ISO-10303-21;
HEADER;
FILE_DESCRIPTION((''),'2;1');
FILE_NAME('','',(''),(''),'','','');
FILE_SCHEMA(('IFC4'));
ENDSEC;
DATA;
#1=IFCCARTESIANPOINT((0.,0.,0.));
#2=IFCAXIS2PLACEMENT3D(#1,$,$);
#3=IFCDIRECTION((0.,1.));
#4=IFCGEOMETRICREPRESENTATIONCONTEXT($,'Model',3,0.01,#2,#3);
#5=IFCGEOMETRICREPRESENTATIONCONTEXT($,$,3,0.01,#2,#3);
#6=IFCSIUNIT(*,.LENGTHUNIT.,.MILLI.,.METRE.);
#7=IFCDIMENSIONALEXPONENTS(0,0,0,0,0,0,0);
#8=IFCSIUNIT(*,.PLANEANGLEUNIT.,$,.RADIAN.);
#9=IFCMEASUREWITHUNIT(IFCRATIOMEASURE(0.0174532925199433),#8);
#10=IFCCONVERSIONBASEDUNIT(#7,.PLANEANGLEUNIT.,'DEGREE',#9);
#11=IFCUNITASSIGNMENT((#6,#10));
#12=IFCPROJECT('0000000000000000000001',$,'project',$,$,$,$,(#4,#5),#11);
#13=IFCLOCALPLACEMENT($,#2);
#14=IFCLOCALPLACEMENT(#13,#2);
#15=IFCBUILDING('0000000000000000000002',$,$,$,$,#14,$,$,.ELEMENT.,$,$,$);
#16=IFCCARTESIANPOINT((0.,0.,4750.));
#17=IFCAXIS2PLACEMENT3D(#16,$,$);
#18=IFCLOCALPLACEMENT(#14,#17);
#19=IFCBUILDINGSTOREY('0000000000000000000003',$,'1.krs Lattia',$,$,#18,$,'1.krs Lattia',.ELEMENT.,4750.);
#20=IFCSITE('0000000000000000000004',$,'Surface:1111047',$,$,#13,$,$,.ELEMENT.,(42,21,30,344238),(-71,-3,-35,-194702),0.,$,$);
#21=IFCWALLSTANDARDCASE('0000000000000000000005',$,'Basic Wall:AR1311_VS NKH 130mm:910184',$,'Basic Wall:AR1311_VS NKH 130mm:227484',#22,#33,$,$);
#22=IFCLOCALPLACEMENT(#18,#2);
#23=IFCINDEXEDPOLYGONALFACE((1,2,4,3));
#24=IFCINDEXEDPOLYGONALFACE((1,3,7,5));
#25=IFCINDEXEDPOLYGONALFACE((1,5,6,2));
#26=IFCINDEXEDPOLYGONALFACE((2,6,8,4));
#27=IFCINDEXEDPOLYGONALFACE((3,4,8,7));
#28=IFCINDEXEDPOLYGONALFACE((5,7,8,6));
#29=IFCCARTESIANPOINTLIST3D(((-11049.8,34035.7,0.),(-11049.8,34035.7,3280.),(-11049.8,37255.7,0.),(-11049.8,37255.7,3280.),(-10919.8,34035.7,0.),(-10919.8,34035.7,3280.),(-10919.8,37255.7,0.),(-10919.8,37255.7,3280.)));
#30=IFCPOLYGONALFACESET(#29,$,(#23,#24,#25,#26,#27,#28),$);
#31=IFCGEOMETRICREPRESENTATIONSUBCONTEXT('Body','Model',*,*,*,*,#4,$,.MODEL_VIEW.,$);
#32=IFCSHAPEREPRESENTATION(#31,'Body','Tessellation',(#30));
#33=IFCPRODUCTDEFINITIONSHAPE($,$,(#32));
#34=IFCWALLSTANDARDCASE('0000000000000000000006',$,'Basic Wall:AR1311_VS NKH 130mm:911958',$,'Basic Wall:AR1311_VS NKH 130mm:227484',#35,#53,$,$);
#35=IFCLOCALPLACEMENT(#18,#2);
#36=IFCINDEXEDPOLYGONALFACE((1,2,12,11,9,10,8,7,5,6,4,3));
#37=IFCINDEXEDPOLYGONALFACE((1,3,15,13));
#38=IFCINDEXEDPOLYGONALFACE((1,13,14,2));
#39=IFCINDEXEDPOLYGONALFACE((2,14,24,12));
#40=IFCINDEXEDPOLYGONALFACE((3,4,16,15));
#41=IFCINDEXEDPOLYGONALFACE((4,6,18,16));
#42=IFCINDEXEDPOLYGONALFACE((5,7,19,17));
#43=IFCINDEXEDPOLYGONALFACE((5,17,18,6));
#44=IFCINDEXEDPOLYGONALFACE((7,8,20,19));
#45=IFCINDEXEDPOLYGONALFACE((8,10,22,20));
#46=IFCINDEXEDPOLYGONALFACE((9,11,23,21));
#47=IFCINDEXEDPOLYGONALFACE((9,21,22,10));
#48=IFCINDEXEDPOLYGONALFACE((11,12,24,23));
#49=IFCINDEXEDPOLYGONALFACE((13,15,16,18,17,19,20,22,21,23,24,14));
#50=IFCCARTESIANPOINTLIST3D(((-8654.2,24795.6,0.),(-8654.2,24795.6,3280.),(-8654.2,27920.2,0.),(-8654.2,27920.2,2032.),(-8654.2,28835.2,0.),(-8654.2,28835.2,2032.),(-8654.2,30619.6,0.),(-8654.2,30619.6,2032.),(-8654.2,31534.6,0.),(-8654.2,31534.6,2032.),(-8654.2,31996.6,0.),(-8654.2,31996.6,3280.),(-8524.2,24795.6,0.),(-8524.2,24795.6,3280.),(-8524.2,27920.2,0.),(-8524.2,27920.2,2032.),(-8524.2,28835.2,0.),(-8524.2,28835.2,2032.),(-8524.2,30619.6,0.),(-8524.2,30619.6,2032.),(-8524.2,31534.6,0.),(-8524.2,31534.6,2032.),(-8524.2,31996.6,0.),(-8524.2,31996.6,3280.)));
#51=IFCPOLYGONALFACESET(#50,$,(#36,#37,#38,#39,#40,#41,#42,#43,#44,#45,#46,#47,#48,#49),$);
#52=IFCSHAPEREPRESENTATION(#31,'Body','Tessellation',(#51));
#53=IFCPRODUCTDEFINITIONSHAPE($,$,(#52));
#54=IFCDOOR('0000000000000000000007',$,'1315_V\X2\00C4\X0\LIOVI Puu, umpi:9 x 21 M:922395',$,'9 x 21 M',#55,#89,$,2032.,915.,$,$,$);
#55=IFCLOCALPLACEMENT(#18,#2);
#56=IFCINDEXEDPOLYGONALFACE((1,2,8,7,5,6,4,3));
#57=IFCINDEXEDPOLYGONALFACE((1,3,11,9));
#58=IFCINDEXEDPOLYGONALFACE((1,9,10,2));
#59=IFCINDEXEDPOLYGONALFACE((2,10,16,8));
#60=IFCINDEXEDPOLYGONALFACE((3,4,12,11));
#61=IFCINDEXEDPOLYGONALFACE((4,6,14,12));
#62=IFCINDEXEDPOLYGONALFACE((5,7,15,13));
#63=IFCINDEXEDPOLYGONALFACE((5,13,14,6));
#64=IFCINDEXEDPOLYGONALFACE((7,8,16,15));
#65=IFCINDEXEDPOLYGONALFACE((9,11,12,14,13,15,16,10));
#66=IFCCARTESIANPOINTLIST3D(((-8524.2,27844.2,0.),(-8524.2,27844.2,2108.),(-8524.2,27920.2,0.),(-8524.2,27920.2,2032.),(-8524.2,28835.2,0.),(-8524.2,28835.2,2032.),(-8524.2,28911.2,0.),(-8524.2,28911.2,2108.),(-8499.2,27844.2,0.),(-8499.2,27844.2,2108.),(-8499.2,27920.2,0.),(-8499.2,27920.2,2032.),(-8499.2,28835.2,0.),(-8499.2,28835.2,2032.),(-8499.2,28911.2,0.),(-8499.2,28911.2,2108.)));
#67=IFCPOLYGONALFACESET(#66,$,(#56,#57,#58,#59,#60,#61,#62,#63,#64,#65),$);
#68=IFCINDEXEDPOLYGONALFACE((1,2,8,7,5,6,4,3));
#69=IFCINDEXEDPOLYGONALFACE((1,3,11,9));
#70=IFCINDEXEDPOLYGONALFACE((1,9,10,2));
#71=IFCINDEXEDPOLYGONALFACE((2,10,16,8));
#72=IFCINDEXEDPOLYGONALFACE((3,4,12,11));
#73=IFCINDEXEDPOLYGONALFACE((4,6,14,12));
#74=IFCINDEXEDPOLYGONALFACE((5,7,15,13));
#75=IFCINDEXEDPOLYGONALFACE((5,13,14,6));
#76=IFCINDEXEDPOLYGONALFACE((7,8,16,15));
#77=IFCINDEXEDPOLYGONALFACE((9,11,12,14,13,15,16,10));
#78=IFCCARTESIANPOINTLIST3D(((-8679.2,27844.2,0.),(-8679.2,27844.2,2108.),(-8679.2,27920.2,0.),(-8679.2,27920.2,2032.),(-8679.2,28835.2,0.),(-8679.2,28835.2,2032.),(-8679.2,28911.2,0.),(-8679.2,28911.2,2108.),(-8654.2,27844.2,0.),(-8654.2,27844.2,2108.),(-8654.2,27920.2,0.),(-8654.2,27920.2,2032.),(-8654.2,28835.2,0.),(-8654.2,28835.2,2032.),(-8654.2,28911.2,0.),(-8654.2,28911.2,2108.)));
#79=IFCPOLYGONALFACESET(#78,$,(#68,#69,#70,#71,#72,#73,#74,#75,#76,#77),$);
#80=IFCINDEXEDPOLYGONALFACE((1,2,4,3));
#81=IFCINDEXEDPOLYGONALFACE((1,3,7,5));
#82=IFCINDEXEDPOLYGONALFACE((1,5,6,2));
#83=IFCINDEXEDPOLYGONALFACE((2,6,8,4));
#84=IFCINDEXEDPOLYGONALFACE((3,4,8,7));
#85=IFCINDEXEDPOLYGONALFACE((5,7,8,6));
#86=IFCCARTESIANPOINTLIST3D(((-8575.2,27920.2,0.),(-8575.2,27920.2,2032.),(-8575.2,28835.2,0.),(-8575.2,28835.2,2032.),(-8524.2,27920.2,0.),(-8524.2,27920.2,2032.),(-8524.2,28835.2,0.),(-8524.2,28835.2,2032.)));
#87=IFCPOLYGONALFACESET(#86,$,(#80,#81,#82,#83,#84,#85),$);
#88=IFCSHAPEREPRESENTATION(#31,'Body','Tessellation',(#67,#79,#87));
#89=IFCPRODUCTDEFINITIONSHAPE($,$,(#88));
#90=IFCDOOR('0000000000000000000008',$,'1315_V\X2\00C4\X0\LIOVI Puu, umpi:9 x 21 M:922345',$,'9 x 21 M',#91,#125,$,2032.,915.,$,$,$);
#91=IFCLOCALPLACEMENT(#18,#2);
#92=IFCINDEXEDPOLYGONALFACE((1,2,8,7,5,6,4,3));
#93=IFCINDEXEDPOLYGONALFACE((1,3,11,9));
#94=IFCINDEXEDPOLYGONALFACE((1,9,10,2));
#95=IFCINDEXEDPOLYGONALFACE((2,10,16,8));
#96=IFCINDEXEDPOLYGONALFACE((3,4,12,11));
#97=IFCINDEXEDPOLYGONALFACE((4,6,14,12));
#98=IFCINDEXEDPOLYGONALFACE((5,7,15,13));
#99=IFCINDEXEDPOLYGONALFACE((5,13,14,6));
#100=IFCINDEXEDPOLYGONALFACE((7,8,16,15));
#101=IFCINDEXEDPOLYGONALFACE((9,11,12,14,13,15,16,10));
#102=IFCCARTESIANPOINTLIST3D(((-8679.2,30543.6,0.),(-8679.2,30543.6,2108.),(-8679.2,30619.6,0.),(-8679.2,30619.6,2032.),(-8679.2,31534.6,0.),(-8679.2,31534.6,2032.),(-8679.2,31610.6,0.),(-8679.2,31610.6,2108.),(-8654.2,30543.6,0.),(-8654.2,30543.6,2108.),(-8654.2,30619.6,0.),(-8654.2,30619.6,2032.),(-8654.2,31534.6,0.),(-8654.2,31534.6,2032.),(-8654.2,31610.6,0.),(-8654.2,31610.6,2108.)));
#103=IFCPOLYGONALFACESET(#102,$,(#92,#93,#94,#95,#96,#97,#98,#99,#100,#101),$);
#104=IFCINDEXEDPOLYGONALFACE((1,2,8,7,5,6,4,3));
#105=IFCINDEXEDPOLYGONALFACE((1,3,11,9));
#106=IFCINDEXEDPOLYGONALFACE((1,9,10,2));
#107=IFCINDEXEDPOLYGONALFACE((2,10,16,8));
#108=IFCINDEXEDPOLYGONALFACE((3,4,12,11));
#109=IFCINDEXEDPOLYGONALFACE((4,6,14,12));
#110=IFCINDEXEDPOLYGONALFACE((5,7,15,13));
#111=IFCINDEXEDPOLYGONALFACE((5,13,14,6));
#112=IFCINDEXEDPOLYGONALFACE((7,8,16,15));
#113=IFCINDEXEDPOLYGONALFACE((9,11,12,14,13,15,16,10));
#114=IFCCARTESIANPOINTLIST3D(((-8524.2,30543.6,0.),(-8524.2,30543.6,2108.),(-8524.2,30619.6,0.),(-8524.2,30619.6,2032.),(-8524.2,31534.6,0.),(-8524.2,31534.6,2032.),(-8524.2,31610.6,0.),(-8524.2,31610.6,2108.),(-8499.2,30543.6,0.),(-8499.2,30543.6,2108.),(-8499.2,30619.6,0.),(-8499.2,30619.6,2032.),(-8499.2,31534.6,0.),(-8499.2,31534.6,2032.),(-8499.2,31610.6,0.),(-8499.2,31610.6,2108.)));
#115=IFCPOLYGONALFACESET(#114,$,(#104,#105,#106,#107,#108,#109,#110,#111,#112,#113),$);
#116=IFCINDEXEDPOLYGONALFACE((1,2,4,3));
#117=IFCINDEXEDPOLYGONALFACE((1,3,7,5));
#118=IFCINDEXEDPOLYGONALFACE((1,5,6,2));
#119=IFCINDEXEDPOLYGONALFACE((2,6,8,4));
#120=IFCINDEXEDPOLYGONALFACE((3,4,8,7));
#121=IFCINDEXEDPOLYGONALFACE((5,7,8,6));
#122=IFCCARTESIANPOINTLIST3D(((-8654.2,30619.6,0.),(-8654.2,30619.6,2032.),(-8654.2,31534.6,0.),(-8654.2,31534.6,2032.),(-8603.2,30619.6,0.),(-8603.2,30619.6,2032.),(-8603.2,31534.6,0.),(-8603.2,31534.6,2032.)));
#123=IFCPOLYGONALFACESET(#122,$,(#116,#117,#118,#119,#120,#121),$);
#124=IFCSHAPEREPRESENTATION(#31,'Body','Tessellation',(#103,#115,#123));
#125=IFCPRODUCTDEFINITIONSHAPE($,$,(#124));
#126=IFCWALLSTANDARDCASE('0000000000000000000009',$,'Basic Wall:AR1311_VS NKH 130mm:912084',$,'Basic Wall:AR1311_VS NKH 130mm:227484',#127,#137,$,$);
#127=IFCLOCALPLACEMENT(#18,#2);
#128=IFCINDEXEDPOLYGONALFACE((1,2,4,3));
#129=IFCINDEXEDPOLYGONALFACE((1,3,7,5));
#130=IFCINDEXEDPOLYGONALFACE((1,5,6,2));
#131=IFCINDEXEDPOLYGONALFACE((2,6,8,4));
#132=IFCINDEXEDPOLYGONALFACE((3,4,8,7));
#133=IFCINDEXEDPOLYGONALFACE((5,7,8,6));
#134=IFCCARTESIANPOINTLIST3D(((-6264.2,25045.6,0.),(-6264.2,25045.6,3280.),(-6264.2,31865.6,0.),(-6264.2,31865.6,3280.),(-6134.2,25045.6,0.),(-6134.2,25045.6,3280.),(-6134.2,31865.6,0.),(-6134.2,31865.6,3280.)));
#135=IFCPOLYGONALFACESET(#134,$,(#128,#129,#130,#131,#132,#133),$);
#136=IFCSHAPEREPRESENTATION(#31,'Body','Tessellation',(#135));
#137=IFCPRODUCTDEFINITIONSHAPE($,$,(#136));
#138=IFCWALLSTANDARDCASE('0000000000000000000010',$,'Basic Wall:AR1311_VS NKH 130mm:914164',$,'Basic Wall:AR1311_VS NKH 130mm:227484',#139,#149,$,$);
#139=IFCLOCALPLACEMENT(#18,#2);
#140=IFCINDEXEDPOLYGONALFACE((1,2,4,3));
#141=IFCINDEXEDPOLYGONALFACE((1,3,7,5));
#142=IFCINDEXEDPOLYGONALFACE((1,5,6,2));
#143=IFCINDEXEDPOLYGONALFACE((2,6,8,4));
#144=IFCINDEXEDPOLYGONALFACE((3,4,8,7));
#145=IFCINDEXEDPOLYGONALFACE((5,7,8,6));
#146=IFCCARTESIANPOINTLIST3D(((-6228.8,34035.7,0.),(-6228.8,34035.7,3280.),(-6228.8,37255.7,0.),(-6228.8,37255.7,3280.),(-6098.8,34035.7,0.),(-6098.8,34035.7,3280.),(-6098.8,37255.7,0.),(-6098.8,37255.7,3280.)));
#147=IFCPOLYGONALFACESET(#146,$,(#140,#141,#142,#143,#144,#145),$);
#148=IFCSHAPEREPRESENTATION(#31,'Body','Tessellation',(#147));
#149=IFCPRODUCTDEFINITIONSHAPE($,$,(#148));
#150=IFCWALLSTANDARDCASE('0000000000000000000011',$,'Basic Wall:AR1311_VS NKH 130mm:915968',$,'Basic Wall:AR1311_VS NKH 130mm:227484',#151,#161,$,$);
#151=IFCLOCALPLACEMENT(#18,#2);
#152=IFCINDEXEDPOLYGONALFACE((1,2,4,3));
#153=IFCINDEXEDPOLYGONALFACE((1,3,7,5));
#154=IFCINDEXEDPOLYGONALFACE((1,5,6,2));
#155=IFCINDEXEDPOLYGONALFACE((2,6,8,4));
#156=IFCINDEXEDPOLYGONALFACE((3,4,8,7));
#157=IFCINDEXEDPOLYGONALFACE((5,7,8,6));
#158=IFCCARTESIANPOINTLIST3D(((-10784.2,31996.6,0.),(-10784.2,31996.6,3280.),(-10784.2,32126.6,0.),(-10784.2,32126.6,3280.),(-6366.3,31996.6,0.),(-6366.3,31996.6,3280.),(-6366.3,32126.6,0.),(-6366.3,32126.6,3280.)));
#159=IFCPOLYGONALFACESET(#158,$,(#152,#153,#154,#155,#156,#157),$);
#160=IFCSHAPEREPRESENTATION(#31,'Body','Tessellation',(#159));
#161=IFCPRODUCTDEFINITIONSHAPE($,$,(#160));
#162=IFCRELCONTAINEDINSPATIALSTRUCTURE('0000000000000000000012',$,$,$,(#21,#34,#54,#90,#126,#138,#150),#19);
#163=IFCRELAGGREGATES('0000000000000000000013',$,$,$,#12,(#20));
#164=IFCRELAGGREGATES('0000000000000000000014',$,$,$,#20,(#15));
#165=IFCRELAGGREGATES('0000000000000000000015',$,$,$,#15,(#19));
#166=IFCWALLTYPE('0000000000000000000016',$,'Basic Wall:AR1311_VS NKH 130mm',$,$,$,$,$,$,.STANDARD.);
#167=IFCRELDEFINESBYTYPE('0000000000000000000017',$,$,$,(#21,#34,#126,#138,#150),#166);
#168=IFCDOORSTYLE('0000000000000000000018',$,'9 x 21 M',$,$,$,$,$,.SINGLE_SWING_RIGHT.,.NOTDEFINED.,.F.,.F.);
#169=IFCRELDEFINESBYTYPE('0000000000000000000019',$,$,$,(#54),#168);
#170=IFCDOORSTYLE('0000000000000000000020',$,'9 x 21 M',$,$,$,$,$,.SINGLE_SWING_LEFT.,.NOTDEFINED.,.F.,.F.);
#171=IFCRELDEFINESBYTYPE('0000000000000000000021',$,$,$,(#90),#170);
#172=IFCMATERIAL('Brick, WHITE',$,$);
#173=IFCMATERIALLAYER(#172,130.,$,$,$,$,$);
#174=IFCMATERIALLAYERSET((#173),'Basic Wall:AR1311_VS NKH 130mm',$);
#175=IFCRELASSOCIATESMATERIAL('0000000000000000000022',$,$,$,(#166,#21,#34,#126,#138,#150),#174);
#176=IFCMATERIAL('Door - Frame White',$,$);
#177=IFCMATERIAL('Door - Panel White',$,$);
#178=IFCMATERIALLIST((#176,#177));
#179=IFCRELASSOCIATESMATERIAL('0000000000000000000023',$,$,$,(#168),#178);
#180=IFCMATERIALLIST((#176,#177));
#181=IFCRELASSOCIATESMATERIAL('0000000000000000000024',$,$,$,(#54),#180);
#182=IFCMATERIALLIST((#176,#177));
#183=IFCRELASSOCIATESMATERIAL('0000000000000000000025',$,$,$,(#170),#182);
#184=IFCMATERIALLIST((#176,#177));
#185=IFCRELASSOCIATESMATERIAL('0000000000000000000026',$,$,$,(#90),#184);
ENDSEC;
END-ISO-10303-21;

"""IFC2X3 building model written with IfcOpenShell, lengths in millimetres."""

from ifc_helpers import new_model, entity, si_unit, converted_unit, direction, frame, frame_2d, origin, place, context, subcontext, project, spatial, polyline, rectangle, outline, extrude, clip, bounded_halfspace, source, transform, mapped, material, material_list, layer, layer_set, layer_usage, type_object, type_shapes, element, fill, save


model = new_model("IFC2X3")

# Units and contexts
model_context = context("Model", 3, precision=0.01, world=origin(), true_north=direction((0.0, 1.0)))
context_of_model = context(None, 3, precision=0.01, world=origin(), true_north=direction((0.0, 1.0)))
body_context = subcontext(model_context, "Body", "Model", "MODEL_VIEW")
ifc_project = project(units=[si_unit("LENGTHUNIT", "METRE", prefix="MILLI"), converted_unit("PLANEANGLEUNIT", "DEGREE", entity("IfcRatioMeasure", 0.0174532925199433), si_unit("PLANEANGLEUNIT", "RADIAN"), dimensions=[0, 0, 0, 0, 0, 0, 0])], contexts=[model_context, context_of_model])

# Site, building, storey
site_placement = place(None, origin())
site = spatial("IfcSite", under=ifc_project, at=site_placement, Name="Surface:1111047", CompositionType="ELEMENT", RefLatitude=(42, 21, 30, 344238), RefLongitude=(-71, -3, -35, -194702), RefElevation=0.0)
building_placement = place(site_placement, origin())
building = spatial("IfcBuilding", under=site, at=building_placement, CompositionType="ELEMENT")
storey_placement = place(building_placement, frame((0.0, 0.0, 4750.0)))
storey = spatial("IfcBuildingStorey", under=building, at=storey_placement, Name="1.krs Lattia", LongName="1.krs Lattia", CompositionType="ELEMENT", Elevation=4750.0)

# Wall
ifc_material_1 = material(Name="Brick, WHITE")
ifc_layer = layer(ifc_material_1, 130.0)
ifc_layer_set = layer_set([ifc_layer], Name="Basic Wall:AR1311_VS NKH 130mm")
ifc_layer_usage_1 = layer_usage(ifc_layer_set, "AXIS2", "NEGATIVE", 65.0)
wall_type = type_object("IfcWallType", Name="Basic Wall:AR1311_VS NKH 130mm", PredefinedType="STANDARD", material=ifc_layer_set)
wall_1_placement = place(storey_placement, frame((-10984.8, 37255.7, 0.0), z_axis=(0.0, 0.0, 1.0), x_axis=(0.0, -1.0, 0.0)))
element("IfcWallStandardCase", 1, at=wall_1_placement, inside=storey, type_object=wall_type, material=ifc_layer_usage_1, Name="Basic Wall:AR1311_VS NKH 130mm:910184", ObjectType="Basic Wall:AR1311_VS NKH 130mm:227484", context=body_context, shape_type="Clipping", body=[
    clip(extrude(rectangle(XDim=3220.0, YDim=130.0, at=frame_2d((1610.0, 0.0), x_axis=(-1.0, 0.0))), origin(), (0.0, 0.0, 1.0), 3280.0), bounded_halfspace(frame((0.0, -65.0, 3280.0), z_axis=(0.0, 0.0, -1.0), x_axis=(-1.0, 0.0, 0.0)), True, frame((0.0, -65.0, 3280.0)), polyline([(0.0, 0.0), (3220.0, 0.0), (3220.0, 130.0), (0.0, 130.0), (0.0, 0.0)]))),
])

# Wall, openings, doors
ifc_layer_usage_2 = layer_usage(ifc_layer_set, "AXIS2", "NEGATIVE", 65.0)
wall_2_placement = place(storey_placement, frame((-8589.2, 31996.6, 0.0), z_axis=(0.0, 0.0, 1.0), x_axis=(0.0, -1.0, 0.0)))
wall_2 = element("IfcWallStandardCase", 2, at=wall_2_placement, inside=storey, type_object=wall_type, material=ifc_layer_usage_2, Name="Basic Wall:AR1311_VS NKH 130mm:911958", ObjectType="Basic Wall:AR1311_VS NKH 130mm:227484", context=body_context, shape_type="Clipping", body=[
    clip(extrude(rectangle(XDim=7201.0, YDim=130.0, at=frame_2d((3600.5, 0.0), x_axis=(-1.0, 0.0))), origin(), (0.0, 0.0, 1.0), 3280.0), bounded_halfspace(frame((0.0, -65.0, 3280.0), z_axis=(0.0, 0.0, -1.0), x_axis=(-1.0, 0.0, 0.0)), True, frame((0.0, -65.0, 3280.0)), polyline([(0.0, 0.0), (2399.6, 0.0), (2529.6, 0.0), (7201.0, 0.0), (7201.0, 130.0), (1607.0, 130.0), (1477.0, 130.0), (0.0, 130.0), (0.0, 0.0)]))),
])
opening_1_placement = place(wall_2_placement, frame((1377.0, 65.0, 0.0)))
opening_1 = element("IfcOpeningElement", 3, at=opening_1_placement, cuts=wall_2, ObjectType="Opening", context=body_context, shape_type="SweptSolid", body=[
    extrude(rectangle(XDim=915.0, YDim=2032.0, at=frame_2d((1016.0, 457.5), x_axis=(0.0, -1.0))), frame((0.0, 0.0, 0.0), z_axis=(0.0, -1.0, 0.0), x_axis=(0.0, 0.0, 1.0)), (0.0, 0.0, 1.0), 130.0),
])
opening_2_placement = place(wall_2_placement, frame((3161.4, -65.0, 0.0)))
opening_2 = element("IfcOpeningElement", 4, at=opening_2_placement, cuts=wall_2, ObjectType="Opening", context=body_context, shape_type="SweptSolid", body=[
    extrude(rectangle(XDim=915.0, YDim=2032.0, at=frame_2d((1016.0, 457.5), x_axis=(0.0, 1.0))), frame((0.0, 0.0, 0.0), z_axis=(0.0, 1.0, 0.0), x_axis=(0.0, 0.0, 1.0)), (0.0, 0.0, 1.0), 130.0),
])
ifc_material_2 = material(Name="Door - Frame White")
ifc_material_3 = material(Name="Door - Panel White")
ifc_material_list_1 = material_list([ifc_material_2, ifc_material_3])
ifc_material_list_2 = material_list([ifc_material_2, ifc_material_3])
door_style_1 = type_object("IfcDoorStyle", Name="9 x 21 M", ConstructionType="NOTDEFINED", OperationType="SINGLE_SWING_RIGHT", ParameterTakesPrecedence=False, Sizeable=False, material=ifc_material_list_2)
shared_shape_1 = source(origin(), body_context, "Body", "SweptSolid", [
    extrude(outline(polyline([(-533.5, -1073.0), (533.5, -1073.0), (533.5, 1035.0), (457.5, 1035.0), (457.5, -997.0), (-457.5, -997.0), (-457.5, 1035.0), (-533.5, 1035.0), (-533.5, -1073.0)])), frame((457.5, 130.0, 1035.0), z_axis=(0.0, 1.0, 0.0), x_axis=(1.0, 0.0, 0.0)), (0.0, 0.0, 1.0), 25.0),
    extrude(outline(polyline([(-1073.0, -533.5), (1035.0, -533.5), (1035.0, -457.5), (-997.0, -457.5), (-997.0, 457.5), (1035.0, 457.5), (1035.0, 533.5), (-1073.0, 533.5), (-1073.0, -533.5)])), frame((457.5, -25.0, 1035.0), z_axis=(0.0, 1.0, 0.0), x_axis=(0.0, 0.0, -1.0)), (0.0, 0.0, 1.0), 25.0),
    extrude(rectangle(XDim=51.0, YDim=915.0, at=frame_2d((0.0, 0.0), x_axis=(1.0, 0.0))), frame((457.5, 104.5, 0.0), z_axis=(0.0, 0.0, 1.0), x_axis=(0.0, 1.0, 0.0)), (0.0, 0.0, 1.0), 2032.0),
])
type_shapes(door_style_1, [shared_shape_1])
door_1_placement = place(opening_2_placement, origin())
door_1 = element("IfcDoor", 5, at=door_1_placement, inside=storey, type_object=door_style_1, material=ifc_material_list_1, Name="1315_VÄLIOVI Puu, umpi:9 x 21 M:922395", ObjectType="9 x 21 M", OverallHeight=2032.0, OverallWidth=915.0, context=body_context, shape_type="MappedRepresentation", body=[
    mapped(shared_shape_1, transform((0.0, 0.0, 0.0), scale=1.0)),
])
fill(opening_2, door_1)
ifc_material_list_3 = material_list([ifc_material_2, ifc_material_3])
ifc_material_list_4 = material_list([ifc_material_2, ifc_material_3])
door_style_2 = type_object("IfcDoorStyle", Name="9 x 21 M", ConstructionType="NOTDEFINED", OperationType="SINGLE_SWING_LEFT", ParameterTakesPrecedence=False, Sizeable=False, material=ifc_material_list_4)
shared_shape_2 = source(origin(), body_context, "Body", "SweptSolid", [
    extrude(outline(polyline([(-533.5, -1073.0), (533.5, -1073.0), (533.5, 1035.0), (457.5, 1035.0), (457.5, -997.0), (-457.5, -997.0), (-457.5, 1035.0), (-533.5, 1035.0), (-533.5, -1073.0)])), frame((457.5, 155.0, 1035.0), z_axis=(0.0, -1.0, 0.0), x_axis=(-1.0, 0.0, 0.0)), (0.0, 0.0, 1.0), 25.0),
    extrude(outline(polyline([(-1073.0, -533.5), (1035.0, -533.5), (1035.0, -457.5), (-997.0, -457.5), (-997.0, 457.5), (1035.0, 457.5), (1035.0, 533.5), (-1073.0, 533.5), (-1073.0, -533.5)])), frame((457.5, 0.0, 1035.0), z_axis=(0.0, -1.0, 0.0), x_axis=(0.0, 0.0, -1.0)), (0.0, 0.0, 1.0), 25.0),
    extrude(rectangle(XDim=915.0, YDim=51.0, at=frame_2d((0.0, 0.0), x_axis=(1.0, 0.0))), frame((457.5, 104.5, 0.0)), (0.0, 0.0, 1.0), 2032.0),
])
type_shapes(door_style_2, [shared_shape_2])
door_2_placement = place(opening_1_placement, frame((0.0, 0.0, 0.0), z_axis=(0.0, 0.0, 1.0), x_axis=(-1.0, 0.0, 0.0)))
door_2 = element("IfcDoor", 6, at=door_2_placement, inside=storey, type_object=door_style_2, material=ifc_material_list_3, Name="1315_VÄLIOVI Puu, umpi:9 x 21 M:922345", ObjectType="9 x 21 M", OverallHeight=2032.0, OverallWidth=915.0, context=body_context, shape_type="MappedRepresentation", body=[
    mapped(shared_shape_2, transform((0.0, 0.0, 0.0), scale=1.0)),
])
fill(opening_1, door_2)

# Walls
ifc_layer_usage_3 = layer_usage(ifc_layer_set, "AXIS2", "NEGATIVE", 65.0)
wall_3_placement = place(storey_placement, frame((-6199.2, 31865.6, 0.0), z_axis=(0.0, 0.0, 1.0), x_axis=(0.0, -1.0, 0.0)))
element("IfcWallStandardCase", 7, at=wall_3_placement, inside=storey, type_object=wall_type, material=ifc_layer_usage_3, Name="Basic Wall:AR1311_VS NKH 130mm:912084", ObjectType="Basic Wall:AR1311_VS NKH 130mm:227484", context=body_context, shape_type="Clipping", body=[
    clip(extrude(rectangle(XDim=6820.0, YDim=130.0, at=frame_2d((3410.0, 0.0), x_axis=(-1.0, 0.0))), origin(), (0.0, 0.0, 1.0), 3280.0), bounded_halfspace(frame((0.0, -65.0, 3280.0), z_axis=(0.0, 0.0, -1.0), x_axis=(-1.0, 0.0, 0.0)), True, frame((0.0, -65.0, 3280.0)), polyline([(0.0, 0.0), (1346.0, 0.0), (1476.0, 0.0), (6820.0, 0.0), (6820.0, 130.0), (1476.0, 130.0), (1346.0, 130.0), (0.0, 130.0), (0.0, 0.0)]))),
])
ifc_layer_usage_4 = layer_usage(ifc_layer_set, "AXIS2", "NEGATIVE", 65.0)
wall_4_placement = place(storey_placement, frame((-6163.8, 37255.7, 0.0), z_axis=(0.0, 0.0, 1.0), x_axis=(0.0, -1.0, 0.0)))
element("IfcWallStandardCase", 8, at=wall_4_placement, inside=storey, type_object=wall_type, material=ifc_layer_usage_4, Name="Basic Wall:AR1311_VS NKH 130mm:914164", ObjectType="Basic Wall:AR1311_VS NKH 130mm:227484", context=body_context, shape_type="Clipping", body=[
    clip(extrude(rectangle(XDim=3220.0, YDim=130.0, at=frame_2d((1610.0, 0.0), x_axis=(-1.0, 0.0))), origin(), (0.0, 0.0, 1.0), 3280.0), bounded_halfspace(frame((0.0, -65.0, 3280.0), z_axis=(0.0, 0.0, -1.0), x_axis=(-1.0, 0.0, 0.0)), True, frame((0.0, -65.0, 3280.0)), polyline([(0.0, 0.0), (3220.0, 0.0), (3220.0, 130.0), (0.0, 130.0), (0.0, 0.0)]))),
])
ifc_layer_usage_5 = layer_usage(ifc_layer_set, "AXIS2", "NEGATIVE", 65.0)
wall_5_placement = place(storey_placement, frame((-10784.2, 32061.6, 0.0)))
element("IfcWallStandardCase", 9, at=wall_5_placement, inside=storey, type_object=wall_type, material=ifc_layer_usage_5, Name="Basic Wall:AR1311_VS NKH 130mm:915968", ObjectType="Basic Wall:AR1311_VS NKH 130mm:227484", context=body_context, shape_type="Clipping", body=[
    clip(extrude(rectangle(XDim=4417.9, YDim=130.0, at=frame_2d((2209.0, 0.0), x_axis=(-1.0, 0.0))), origin(), (0.0, 0.0, 1.0), 3280.0), bounded_halfspace(frame((0.0, -65.0, 3280.0), z_axis=(0.0, 0.0, -1.0), x_axis=(0.0, 1.0, 0.0)), True, frame((0.0, -65.0, 3280.0)), polyline([(0.0, 0.0), (2130.0, 0.0), (2260.0, 0.0), (3339.0, 0.0), (3469.0, 0.0), (4417.9, 0.0), (4417.9, 130.0), (0.0, 130.0), (0.0, 0.0)]))),
])

save(model, "model.ifc")
